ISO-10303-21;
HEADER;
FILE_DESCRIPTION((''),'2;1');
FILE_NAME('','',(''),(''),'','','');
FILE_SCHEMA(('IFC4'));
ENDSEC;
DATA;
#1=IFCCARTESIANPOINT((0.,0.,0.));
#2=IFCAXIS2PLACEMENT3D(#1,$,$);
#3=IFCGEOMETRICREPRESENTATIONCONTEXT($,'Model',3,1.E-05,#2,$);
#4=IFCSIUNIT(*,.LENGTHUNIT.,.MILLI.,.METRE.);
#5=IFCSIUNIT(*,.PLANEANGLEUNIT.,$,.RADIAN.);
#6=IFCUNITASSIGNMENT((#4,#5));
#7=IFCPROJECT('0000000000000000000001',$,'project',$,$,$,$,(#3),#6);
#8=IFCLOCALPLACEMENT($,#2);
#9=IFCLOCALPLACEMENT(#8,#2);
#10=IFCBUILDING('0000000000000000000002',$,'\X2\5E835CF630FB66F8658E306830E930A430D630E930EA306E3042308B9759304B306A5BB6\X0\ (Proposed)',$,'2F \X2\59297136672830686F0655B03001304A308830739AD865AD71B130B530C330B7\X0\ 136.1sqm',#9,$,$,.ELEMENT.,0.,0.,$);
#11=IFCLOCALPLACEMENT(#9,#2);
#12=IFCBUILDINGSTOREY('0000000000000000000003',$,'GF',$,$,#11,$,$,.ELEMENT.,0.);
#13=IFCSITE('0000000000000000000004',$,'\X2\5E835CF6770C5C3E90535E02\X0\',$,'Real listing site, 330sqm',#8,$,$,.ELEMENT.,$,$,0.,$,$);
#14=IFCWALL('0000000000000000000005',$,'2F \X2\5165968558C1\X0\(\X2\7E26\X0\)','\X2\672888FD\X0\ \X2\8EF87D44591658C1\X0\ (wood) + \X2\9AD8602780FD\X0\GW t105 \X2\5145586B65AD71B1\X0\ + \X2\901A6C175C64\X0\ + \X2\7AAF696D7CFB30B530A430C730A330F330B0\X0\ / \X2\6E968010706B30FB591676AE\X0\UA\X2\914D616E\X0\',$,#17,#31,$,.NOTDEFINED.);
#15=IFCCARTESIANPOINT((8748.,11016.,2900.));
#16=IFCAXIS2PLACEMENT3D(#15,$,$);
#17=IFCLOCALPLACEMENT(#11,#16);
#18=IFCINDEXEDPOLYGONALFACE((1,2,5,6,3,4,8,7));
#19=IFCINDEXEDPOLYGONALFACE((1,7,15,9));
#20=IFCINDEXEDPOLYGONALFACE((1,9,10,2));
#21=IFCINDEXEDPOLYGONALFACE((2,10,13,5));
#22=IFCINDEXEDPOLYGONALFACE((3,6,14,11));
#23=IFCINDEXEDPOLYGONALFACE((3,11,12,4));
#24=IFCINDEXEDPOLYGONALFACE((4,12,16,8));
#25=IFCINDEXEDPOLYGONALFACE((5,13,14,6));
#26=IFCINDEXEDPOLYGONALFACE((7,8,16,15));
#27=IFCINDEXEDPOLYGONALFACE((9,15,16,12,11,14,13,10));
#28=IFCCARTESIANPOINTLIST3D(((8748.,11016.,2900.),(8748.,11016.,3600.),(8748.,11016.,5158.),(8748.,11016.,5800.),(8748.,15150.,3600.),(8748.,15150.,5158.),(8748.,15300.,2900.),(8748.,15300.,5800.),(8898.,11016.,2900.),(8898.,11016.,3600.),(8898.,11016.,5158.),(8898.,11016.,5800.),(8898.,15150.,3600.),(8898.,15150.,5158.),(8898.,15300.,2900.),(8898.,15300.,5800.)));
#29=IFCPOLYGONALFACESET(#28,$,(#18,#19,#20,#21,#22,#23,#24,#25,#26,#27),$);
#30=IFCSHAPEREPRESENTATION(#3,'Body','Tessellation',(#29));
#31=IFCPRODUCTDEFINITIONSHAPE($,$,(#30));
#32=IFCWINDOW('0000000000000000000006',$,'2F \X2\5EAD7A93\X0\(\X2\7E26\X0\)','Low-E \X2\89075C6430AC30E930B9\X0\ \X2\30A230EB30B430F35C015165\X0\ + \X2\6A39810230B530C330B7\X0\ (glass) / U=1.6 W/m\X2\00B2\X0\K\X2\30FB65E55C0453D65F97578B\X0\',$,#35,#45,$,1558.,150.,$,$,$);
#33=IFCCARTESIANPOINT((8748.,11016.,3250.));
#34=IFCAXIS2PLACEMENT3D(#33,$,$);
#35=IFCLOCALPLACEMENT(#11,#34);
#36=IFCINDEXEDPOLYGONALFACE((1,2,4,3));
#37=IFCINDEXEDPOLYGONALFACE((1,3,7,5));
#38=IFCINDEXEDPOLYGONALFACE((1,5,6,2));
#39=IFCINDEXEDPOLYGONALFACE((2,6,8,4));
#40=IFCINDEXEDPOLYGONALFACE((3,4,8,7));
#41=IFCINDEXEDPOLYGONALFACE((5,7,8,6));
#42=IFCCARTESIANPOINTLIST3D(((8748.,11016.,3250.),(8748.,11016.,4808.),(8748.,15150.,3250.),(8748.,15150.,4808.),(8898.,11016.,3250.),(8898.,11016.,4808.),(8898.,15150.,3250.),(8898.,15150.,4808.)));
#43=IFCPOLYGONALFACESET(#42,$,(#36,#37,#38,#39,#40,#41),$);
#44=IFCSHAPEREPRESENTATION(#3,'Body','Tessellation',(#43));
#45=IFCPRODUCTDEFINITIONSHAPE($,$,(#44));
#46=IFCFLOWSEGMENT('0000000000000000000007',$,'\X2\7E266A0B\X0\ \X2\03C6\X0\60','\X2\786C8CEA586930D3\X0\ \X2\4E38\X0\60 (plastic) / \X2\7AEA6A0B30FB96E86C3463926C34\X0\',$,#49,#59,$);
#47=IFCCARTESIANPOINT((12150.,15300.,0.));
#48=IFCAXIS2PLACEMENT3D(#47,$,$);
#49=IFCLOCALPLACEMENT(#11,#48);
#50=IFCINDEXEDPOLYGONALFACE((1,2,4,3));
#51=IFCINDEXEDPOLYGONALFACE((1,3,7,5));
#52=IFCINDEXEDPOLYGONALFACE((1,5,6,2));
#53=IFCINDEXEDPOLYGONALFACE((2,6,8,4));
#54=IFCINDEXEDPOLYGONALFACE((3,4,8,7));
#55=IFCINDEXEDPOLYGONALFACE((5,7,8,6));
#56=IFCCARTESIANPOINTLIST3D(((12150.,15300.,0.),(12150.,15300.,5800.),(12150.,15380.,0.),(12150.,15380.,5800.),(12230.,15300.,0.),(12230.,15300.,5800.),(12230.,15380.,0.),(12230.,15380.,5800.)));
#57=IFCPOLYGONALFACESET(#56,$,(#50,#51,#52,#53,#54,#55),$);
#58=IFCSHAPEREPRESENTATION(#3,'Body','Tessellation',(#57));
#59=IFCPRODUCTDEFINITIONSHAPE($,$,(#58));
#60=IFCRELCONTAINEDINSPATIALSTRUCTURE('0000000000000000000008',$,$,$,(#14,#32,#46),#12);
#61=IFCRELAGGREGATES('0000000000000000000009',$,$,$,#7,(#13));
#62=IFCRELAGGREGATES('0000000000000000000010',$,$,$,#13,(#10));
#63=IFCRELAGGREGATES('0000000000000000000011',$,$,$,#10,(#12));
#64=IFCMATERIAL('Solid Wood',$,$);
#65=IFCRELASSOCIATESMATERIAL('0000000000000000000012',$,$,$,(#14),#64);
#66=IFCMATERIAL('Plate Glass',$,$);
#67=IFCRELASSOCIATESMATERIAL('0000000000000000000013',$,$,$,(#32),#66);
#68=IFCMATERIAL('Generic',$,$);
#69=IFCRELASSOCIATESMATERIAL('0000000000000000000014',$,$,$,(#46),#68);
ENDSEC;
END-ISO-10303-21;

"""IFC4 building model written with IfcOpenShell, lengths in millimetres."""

from ifc_helpers import new_model, si_unit, frame, frame_2d, origin, place, context, project, spatial, rectangle, extrude, material, element, fill, save


model = new_model("IFC4")

# Units and contexts
model_context = context("Model", 3, precision=1e-05, world=origin())
ifc_project = project(units=[si_unit("LENGTHUNIT", "METRE", prefix="MILLI"), si_unit("PLANEANGLEUNIT", "RADIAN")], contexts=[model_context])

# Site, building, storey
site_placement = place(None, origin())
site = spatial("IfcSite", under=ifc_project, at=site_placement, Name="広島県尾道市", ObjectType="Real listing site, 330sqm", CompositionType="ELEMENT", RefElevation=0.0)
building_placement = place(site_placement, origin())
building = spatial("IfcBuilding", under=site, at=building_placement, Name="広島・書斎とライブラリのある静かな家 (Proposed)", ObjectType="2F 天然木と漆喰、および高断熱サッシ 136.1sqm", CompositionType="ELEMENT", ElevationOfRefHeight=0.0, ElevationOfTerrain=0.0)
storey_placement = place(building_placement, origin())
storey = spatial("IfcBuildingStorey", under=building, at=storey_placement, Name="GF", CompositionType="ELEMENT", Elevation=0.0)

# Shared definitions
ifc_material_1 = material(Name="Solid Wood")

# Shared definitions
ifc_material_2 = material(Name="Plate Glass")

# Wall, opening, window
wall_1_placement = place(storey_placement, frame((8748.0, 11016.0, 2900.0)))
wall_1 = element("IfcWall", 1, at=wall_1_placement, inside=storey, material=ifc_material_1, Name="2F 入隅壁(縦)", Description="木製 軸組外壁 (wood) + 高性能GW t105 充填断熱 + 通気層 + 窯業系サイディング / 準耐火・外皮UA配慮", PredefinedType="NOTDEFINED", context=model_context, shape_type="SweptSolid", body=[
    extrude(rectangle(XDim=150.0, YDim=4284.0, at=frame_2d((75.0, 2142.0))), frame((8748.0, 11016.0, 2900.0)), (0.0, 0.0, 1.0), 2900.0),
])
opening_1_placement = place(storey_placement, frame((8748.0, 11016.0, 3250.0)))
opening_1 = element("IfcOpeningElement", 2, at=opening_1_placement, cuts=wall_1, PredefinedType="NOTDEFINED", context=model_context, shape_type="SweptSolid", body=[
    extrude(rectangle(XDim=150.0, YDim=4134.0, at=frame_2d((75.0, 2067.0))), frame((8748.0, 11016.0, 3250.0)), (0.0, 0.0, 1.0), 1558.0),
])
window_1_placement = place(storey_placement, frame((8748.0, 11016.0, 3250.0)))
window_1 = element("IfcWindow", 3, at=window_1_placement, inside=storey, material=ifc_material_2, Name="2F 庭窓(縦)", Description="Low-E 複層ガラス アルゴン封入 + 樹脂サッシ (glass) / U=1.6 W/m²K・日射取得型", OverallHeight=1558.0, OverallWidth=150.0, context=model_context, shape_type="SweptSolid", body=[
    extrude(rectangle(XDim=150.0, YDim=4134.0, at=frame_2d((75.0, 2067.0))), frame((8748.0, 11016.0, 3250.0)), (0.0, 0.0, 1.0), 1558.0),
])
fill(opening_1, window_1)

# Flow segment
ifc_material_3 = material(Name="Generic")
flow_segment_placement = place(storey_placement, frame((12150.0, 15300.0, 0.0)))
element("IfcFlowSegment", 4, at=flow_segment_placement, inside=storey, material=ifc_material_3, Name="縦樋 φ60", Description="硬質塩ビ 丸60 (plastic) / 竪樋・雨水排水", context=model_context, shape_type="SweptSolid", body=[
    extrude(rectangle(XDim=80.0, YDim=80.0, at=frame_2d((40.0, 40.0))), frame((12150.0, 15300.0, 0.0)), (0.0, 0.0, 1.0), 5800.0),
])

save(model, "model.ifc")
